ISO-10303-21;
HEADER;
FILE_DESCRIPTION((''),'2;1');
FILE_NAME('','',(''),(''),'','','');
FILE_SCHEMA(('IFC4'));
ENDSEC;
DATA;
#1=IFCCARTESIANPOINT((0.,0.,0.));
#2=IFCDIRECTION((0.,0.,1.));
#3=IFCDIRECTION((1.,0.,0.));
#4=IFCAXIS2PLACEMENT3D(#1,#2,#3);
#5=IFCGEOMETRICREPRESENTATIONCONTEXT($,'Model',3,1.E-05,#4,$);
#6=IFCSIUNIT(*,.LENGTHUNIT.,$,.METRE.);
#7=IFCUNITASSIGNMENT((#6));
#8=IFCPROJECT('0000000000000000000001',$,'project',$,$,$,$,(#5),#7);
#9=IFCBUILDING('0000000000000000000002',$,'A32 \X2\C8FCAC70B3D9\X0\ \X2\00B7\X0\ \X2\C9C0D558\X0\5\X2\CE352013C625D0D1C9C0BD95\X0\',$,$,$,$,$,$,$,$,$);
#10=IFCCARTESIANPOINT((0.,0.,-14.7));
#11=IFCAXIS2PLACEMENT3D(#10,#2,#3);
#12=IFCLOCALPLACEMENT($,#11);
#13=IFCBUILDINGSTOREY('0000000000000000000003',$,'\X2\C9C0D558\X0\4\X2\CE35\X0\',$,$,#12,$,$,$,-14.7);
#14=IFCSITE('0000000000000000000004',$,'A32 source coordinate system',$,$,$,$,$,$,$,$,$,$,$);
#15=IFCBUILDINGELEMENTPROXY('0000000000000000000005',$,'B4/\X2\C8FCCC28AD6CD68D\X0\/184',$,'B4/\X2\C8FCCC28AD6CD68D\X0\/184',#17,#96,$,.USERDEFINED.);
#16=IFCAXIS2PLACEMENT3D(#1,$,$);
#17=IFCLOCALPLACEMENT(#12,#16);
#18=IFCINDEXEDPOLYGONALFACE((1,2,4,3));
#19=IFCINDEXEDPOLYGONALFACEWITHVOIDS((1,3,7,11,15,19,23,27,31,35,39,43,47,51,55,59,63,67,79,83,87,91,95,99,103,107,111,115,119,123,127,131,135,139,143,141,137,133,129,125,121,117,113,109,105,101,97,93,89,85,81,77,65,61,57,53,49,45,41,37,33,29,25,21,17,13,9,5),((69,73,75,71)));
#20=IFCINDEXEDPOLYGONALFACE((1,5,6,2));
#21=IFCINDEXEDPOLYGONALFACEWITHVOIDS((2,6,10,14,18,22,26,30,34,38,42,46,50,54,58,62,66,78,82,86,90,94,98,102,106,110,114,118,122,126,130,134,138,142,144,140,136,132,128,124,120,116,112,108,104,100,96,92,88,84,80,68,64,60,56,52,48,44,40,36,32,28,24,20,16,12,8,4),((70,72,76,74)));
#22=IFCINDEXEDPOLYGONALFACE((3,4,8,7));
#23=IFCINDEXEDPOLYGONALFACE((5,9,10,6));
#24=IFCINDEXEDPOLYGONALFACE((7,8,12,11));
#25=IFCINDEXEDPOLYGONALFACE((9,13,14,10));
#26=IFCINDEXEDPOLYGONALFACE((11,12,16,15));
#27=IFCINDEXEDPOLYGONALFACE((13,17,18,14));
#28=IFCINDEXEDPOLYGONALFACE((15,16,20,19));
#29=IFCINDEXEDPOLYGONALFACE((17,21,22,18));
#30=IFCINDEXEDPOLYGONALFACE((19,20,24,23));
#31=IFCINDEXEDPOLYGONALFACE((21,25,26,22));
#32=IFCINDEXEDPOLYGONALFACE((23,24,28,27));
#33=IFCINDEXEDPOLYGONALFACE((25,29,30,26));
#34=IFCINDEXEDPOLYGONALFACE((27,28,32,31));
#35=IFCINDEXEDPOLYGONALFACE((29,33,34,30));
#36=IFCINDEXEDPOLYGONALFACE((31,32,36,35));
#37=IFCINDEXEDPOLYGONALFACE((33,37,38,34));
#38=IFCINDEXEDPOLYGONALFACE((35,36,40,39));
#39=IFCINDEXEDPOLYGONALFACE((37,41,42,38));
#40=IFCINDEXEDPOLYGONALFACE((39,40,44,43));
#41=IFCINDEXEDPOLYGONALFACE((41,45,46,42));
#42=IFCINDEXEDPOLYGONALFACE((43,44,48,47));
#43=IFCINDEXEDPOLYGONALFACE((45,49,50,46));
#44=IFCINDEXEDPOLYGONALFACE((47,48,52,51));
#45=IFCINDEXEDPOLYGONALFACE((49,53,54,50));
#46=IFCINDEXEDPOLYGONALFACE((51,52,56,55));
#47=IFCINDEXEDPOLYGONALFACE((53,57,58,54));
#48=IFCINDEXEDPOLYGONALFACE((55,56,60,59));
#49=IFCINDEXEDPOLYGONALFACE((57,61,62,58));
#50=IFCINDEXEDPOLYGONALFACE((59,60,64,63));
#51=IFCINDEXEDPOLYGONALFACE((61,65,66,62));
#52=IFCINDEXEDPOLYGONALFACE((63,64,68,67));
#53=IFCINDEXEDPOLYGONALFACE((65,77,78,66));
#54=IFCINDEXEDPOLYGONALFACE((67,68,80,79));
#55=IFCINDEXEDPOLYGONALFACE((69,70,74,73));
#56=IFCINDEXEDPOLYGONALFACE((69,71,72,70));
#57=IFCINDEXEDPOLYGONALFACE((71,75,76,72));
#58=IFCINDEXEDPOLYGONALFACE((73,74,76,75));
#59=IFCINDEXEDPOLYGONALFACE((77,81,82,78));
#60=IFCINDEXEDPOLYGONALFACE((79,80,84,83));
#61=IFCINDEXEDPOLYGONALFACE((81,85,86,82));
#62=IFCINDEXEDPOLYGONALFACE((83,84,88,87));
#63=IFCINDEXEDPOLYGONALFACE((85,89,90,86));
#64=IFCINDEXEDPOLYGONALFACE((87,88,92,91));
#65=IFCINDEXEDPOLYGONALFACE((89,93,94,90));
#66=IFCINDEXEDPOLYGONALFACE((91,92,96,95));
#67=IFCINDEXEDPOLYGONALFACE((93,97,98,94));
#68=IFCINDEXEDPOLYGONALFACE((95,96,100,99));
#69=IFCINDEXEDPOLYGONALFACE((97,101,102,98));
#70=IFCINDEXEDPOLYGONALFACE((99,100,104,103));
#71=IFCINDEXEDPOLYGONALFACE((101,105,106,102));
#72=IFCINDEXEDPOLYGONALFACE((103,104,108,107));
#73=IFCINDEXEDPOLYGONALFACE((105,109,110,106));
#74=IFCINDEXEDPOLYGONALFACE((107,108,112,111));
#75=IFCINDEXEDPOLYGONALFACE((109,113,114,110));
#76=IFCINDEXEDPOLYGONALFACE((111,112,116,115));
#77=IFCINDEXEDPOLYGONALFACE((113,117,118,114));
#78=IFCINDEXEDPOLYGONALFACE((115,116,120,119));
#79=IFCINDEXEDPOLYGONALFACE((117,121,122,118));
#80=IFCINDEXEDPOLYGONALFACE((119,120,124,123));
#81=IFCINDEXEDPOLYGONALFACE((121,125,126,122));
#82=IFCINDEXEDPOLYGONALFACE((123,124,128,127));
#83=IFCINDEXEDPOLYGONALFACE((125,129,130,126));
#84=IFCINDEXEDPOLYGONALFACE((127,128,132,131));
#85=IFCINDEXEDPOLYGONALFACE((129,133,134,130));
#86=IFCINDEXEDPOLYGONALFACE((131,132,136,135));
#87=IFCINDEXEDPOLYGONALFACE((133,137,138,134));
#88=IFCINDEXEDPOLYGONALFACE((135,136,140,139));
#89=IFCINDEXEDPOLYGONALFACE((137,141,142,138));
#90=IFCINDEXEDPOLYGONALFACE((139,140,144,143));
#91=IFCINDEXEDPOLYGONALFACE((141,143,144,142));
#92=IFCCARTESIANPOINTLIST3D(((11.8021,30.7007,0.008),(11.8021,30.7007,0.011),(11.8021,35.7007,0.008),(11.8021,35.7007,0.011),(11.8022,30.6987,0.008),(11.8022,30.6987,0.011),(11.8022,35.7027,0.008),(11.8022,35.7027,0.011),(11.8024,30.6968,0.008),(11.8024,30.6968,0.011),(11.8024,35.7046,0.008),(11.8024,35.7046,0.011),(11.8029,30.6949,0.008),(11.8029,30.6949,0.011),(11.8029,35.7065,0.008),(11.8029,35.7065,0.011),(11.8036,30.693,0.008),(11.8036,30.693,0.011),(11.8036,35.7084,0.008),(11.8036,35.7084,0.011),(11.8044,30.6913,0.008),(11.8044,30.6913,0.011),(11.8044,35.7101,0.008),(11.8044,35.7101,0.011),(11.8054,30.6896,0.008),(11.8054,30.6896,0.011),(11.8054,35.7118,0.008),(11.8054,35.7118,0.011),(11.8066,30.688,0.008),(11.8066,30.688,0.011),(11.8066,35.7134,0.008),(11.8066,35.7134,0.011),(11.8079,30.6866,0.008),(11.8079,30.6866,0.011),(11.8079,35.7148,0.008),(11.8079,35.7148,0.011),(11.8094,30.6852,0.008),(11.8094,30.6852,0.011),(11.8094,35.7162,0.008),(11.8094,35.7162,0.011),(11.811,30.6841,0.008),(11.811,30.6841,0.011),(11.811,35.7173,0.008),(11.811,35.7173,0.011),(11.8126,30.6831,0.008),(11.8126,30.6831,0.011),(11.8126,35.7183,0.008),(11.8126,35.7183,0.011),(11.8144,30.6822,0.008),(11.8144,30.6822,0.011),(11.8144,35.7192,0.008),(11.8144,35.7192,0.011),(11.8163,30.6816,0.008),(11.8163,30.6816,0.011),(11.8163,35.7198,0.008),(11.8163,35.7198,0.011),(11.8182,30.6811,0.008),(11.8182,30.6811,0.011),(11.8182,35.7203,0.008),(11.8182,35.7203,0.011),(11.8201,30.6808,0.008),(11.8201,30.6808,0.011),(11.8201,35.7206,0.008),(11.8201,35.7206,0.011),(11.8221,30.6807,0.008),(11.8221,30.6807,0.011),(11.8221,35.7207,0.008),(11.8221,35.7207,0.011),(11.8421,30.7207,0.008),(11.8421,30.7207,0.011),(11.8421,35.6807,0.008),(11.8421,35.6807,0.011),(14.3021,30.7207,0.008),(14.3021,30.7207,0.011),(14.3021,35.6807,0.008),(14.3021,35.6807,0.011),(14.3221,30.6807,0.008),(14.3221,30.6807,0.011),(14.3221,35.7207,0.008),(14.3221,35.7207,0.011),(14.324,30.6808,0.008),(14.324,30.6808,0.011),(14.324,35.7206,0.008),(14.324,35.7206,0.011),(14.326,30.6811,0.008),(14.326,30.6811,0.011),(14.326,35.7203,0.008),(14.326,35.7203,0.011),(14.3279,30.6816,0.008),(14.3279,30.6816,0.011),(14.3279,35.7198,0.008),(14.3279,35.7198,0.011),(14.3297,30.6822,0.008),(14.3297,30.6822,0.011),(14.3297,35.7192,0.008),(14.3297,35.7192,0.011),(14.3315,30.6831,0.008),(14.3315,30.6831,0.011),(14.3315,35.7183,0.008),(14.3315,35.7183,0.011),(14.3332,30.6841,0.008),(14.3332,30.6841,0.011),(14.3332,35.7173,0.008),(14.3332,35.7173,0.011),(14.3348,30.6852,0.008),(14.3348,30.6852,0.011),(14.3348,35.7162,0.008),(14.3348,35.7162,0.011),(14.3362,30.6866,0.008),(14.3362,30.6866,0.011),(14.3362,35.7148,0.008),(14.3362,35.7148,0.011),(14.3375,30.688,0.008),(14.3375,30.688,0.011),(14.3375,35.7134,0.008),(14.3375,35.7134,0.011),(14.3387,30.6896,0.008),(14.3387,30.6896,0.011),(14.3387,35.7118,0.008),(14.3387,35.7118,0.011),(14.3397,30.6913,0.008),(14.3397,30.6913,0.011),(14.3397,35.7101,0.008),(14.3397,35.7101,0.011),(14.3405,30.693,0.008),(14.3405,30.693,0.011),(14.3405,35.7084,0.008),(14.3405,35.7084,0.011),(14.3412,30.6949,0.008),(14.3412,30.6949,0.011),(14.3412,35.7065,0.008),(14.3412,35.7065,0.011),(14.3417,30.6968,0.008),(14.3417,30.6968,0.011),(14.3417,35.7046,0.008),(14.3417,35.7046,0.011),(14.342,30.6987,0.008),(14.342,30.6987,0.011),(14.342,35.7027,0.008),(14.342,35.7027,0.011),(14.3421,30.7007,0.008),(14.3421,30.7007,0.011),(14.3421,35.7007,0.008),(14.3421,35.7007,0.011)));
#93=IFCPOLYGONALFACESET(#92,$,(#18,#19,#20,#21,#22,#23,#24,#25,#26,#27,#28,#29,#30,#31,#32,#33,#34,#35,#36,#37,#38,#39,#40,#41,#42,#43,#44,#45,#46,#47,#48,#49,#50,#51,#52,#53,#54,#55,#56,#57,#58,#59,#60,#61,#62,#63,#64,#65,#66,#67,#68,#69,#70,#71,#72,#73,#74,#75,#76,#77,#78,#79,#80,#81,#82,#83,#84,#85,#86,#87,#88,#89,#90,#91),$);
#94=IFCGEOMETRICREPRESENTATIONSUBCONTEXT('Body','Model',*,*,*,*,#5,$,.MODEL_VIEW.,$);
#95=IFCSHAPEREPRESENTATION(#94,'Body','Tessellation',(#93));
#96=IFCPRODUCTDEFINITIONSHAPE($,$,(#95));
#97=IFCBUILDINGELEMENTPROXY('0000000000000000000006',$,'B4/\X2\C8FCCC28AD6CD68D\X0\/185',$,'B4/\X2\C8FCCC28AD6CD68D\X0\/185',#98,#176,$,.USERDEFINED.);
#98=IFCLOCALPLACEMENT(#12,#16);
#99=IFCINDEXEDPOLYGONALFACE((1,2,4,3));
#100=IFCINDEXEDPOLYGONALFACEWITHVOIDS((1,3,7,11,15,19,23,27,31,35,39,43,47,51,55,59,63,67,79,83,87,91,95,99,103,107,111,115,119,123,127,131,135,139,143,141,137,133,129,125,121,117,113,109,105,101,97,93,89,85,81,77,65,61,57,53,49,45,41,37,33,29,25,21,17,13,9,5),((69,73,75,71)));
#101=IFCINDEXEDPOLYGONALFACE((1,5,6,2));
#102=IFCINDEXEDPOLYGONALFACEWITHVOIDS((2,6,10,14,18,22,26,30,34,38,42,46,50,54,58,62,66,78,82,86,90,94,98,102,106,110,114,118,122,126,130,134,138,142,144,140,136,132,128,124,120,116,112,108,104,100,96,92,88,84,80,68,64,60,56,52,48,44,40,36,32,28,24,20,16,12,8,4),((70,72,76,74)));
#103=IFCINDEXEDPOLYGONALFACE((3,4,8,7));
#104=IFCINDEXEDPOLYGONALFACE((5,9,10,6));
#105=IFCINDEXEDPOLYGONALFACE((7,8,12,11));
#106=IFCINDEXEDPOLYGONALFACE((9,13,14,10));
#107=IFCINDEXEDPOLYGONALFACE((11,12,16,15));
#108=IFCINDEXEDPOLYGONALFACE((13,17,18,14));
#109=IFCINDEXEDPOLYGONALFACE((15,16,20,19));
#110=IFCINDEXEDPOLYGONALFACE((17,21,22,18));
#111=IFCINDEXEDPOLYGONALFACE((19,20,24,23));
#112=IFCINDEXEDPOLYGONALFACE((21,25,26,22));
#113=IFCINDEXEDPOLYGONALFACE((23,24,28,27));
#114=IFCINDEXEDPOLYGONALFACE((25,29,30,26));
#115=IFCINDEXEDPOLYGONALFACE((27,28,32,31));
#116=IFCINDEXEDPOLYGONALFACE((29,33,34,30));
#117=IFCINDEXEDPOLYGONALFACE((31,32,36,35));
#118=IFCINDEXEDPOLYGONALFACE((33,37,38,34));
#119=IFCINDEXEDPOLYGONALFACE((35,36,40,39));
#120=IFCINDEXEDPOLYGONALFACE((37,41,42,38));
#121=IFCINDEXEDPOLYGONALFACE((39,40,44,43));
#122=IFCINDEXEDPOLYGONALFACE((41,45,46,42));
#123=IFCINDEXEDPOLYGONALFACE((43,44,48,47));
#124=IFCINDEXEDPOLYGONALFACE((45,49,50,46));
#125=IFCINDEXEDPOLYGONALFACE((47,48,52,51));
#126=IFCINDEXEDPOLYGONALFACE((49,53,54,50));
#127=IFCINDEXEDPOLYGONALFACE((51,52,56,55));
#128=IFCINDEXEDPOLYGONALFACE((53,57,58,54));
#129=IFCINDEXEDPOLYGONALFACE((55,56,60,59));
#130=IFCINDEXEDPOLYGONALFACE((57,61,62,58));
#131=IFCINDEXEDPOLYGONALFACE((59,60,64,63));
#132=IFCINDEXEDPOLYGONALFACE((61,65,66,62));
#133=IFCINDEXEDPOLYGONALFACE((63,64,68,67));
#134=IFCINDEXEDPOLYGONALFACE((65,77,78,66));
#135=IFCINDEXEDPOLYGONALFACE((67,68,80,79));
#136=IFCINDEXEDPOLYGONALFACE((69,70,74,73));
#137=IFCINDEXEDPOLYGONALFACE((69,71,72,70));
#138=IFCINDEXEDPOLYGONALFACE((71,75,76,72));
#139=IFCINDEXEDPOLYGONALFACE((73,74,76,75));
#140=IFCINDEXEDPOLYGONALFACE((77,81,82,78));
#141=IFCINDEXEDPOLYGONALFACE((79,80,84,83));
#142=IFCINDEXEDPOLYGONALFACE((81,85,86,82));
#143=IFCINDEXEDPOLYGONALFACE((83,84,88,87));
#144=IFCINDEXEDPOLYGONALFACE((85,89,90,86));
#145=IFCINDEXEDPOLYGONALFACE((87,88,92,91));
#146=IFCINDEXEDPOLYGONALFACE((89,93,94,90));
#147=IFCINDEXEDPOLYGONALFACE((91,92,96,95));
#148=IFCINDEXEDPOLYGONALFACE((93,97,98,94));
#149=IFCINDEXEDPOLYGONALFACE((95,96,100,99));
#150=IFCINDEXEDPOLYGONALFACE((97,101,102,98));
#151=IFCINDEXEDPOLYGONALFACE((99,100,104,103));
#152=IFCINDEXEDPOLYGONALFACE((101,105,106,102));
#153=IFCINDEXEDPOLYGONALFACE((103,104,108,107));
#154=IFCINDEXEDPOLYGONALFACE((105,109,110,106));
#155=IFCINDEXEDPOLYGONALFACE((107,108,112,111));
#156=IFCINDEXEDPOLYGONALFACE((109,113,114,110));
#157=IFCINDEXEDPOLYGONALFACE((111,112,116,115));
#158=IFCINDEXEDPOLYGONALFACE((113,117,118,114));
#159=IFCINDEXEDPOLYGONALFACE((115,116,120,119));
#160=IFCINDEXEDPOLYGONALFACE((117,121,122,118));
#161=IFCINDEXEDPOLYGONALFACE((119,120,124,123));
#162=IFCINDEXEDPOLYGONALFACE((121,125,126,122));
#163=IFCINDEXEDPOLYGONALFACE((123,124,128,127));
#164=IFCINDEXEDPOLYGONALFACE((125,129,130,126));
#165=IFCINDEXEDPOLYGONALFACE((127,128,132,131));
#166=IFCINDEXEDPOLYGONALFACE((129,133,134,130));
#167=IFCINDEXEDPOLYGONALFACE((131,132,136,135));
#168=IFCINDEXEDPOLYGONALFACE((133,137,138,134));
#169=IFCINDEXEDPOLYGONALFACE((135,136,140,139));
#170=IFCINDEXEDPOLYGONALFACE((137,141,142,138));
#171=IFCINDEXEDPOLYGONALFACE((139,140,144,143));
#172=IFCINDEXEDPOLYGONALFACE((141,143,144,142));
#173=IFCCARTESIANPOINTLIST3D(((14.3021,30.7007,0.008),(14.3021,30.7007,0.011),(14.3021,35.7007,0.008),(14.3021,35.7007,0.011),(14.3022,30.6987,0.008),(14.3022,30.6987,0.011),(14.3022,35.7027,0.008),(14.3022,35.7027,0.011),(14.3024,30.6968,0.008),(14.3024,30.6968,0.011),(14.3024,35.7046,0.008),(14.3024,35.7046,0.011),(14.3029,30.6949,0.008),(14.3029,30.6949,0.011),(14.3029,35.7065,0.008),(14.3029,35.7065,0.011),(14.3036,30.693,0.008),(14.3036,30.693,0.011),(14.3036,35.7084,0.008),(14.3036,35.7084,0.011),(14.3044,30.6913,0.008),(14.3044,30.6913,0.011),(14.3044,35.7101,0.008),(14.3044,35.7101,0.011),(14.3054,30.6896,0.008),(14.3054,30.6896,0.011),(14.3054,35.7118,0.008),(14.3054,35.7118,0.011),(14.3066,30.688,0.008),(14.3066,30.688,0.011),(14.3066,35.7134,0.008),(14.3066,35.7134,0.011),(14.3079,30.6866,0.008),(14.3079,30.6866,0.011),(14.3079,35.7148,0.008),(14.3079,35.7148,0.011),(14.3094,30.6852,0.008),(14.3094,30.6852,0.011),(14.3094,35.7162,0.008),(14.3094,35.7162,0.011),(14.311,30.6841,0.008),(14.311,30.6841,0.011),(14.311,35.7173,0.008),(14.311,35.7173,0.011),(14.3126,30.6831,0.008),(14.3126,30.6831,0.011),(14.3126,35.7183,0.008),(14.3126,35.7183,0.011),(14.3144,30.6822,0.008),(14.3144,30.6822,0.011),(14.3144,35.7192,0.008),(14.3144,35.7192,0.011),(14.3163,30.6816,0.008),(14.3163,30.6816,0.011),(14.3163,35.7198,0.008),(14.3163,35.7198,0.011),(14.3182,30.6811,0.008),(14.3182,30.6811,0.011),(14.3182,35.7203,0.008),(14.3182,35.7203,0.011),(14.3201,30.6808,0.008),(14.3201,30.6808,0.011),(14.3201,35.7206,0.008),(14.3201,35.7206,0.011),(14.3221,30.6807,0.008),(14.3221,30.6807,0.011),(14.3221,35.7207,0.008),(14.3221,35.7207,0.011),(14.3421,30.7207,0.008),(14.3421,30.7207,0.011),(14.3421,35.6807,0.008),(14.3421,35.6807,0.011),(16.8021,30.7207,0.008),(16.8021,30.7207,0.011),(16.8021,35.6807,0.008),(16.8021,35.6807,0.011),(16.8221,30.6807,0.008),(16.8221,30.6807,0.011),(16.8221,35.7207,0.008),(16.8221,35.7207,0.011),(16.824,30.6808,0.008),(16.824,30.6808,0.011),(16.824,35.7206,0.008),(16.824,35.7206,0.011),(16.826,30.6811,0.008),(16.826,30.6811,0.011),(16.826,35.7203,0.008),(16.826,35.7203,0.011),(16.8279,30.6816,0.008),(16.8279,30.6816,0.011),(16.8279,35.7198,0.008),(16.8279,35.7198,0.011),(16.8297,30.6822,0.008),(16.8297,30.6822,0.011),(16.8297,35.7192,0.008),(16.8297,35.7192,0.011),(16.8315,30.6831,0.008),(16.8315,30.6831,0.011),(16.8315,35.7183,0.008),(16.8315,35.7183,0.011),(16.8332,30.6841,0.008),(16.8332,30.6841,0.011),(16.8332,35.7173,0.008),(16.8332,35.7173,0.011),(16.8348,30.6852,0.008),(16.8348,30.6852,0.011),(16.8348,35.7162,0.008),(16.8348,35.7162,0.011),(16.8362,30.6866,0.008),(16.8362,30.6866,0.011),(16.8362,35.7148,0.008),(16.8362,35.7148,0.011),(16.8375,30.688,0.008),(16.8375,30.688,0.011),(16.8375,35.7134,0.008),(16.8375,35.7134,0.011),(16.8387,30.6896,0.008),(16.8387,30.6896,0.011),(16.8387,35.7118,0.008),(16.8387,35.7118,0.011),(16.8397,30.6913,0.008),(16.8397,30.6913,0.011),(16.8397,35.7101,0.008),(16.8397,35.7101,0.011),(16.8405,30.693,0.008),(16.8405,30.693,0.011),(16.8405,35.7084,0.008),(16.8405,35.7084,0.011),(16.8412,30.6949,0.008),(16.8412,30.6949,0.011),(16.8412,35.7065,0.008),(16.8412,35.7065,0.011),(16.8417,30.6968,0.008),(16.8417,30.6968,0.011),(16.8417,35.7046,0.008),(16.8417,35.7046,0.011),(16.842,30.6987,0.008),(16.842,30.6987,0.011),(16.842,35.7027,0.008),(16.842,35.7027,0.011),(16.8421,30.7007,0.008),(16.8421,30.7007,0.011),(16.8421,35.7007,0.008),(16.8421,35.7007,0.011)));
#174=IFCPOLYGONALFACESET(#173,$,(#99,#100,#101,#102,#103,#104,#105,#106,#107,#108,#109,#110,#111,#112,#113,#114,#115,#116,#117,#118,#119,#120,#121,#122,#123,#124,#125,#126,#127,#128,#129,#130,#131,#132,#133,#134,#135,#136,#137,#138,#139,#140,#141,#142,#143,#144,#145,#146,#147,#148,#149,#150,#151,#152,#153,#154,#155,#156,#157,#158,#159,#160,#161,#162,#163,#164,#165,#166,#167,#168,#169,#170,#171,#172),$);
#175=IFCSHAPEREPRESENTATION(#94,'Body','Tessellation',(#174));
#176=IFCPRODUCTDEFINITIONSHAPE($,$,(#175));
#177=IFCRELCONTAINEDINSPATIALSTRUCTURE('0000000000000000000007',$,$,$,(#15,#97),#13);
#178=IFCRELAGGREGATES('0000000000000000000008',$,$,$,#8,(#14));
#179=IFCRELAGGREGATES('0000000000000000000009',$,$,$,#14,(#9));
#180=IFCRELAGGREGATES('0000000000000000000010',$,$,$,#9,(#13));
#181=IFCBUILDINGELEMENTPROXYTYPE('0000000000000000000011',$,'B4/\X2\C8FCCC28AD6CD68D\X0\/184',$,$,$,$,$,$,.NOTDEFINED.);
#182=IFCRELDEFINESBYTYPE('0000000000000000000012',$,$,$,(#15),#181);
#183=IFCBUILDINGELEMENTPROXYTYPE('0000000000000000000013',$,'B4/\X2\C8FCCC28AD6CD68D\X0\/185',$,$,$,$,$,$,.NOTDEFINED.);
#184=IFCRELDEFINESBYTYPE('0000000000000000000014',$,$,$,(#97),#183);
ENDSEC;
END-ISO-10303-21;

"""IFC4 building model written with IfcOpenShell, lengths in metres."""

from ifc_helpers import new_model, si_unit, frame, origin, origin_with_axes, place, context, subcontext, project, spatial, polyline, outline, extrude, source, transform, mapped, type_object, type_shapes, element, save


model = new_model("IFC4")

# Units and contexts
model_context = context("Model", 3, precision=1e-05, world=origin_with_axes())
body_context = subcontext(model_context, "Body", "Model", "MODEL_VIEW")
ifc_project = project(units=[si_unit("LENGTHUNIT", "METRE")], contexts=[model_context])

# Site, building, storey
site = spatial("IfcSite", under=ifc_project, Name="A32 source coordinate system")
building = spatial("IfcBuilding", under=site, Name="A32 주거동 · 지하5층–옥탑지붕")
storey_placement = place(None, frame((0.0, 0.0, -14.7), z_axis=(0.0, 0.0, 1.0), x_axis=(1.0, 0.0, 0.0)))
storey = spatial("IfcBuildingStorey", under=building, at=storey_placement, Name="지하4층", Elevation=-14.7)

# Building element proxies
building_element_proxy_type_1 = type_object("IfcBuildingElementProxyType", Name="B4/주차구획/184", PredefinedType="NOTDEFINED")
shared_shape_1 = source(origin(), body_context, "Body", "SweptSolid", [
    extrude(outline(polyline([(11.8021, 35.7007), (11.8022, 35.7027), (11.8024, 35.7046), (11.8029, 35.7065), (11.8036, 35.7084), (11.8044, 35.7101), (11.8054, 35.7118), (11.8066, 35.7134), (11.8079, 35.7148), (11.8094, 35.7162), (11.811, 35.7173), (11.8126, 35.7183), (11.8144, 35.7192), (11.8163, 35.7198), (11.8182, 35.7203), (11.8201, 35.7206), (11.8221, 35.7207), (14.3221, 35.7207), (14.324, 35.7206), (14.326, 35.7203), (14.3279, 35.7198), (14.3297, 35.7192), (14.3315, 35.7183), (14.3332, 35.7173), (14.3348, 35.7162), (14.3362, 35.7148), (14.3375, 35.7134), (14.3387, 35.7118), (14.3397, 35.7101), (14.3405, 35.7084), (14.3412, 35.7065), (14.3417, 35.7046), (14.342, 35.7027), (14.3421, 35.7007), (14.3421, 30.7007), (14.342, 30.6987), (14.3417, 30.6968), (14.3412, 30.6949), (14.3405, 30.693), (14.3397, 30.6913), (14.3387, 30.6896), (14.3375, 30.688), (14.3362, 30.6866), (14.3348, 30.6852), (14.3332, 30.6841), (14.3315, 30.6831), (14.3297, 30.6822), (14.3279, 30.6816), (14.326, 30.6811), (14.324, 30.6808), (14.3221, 30.6807), (11.8221, 30.6807), (11.8201, 30.6808), (11.8182, 30.6811), (11.8163, 30.6816), (11.8144, 30.6822), (11.8126, 30.6831), (11.811, 30.6841), (11.8094, 30.6852), (11.8079, 30.6866), (11.8066, 30.688), (11.8054, 30.6896), (11.8044, 30.6913), (11.8036, 30.693), (11.8029, 30.6949), (11.8024, 30.6968), (11.8022, 30.6987), (11.8021, 30.7007), (11.8021, 35.7007)]), holes=[polyline([(11.8421, 35.6807), (11.8421, 30.7207), (14.3021, 30.7207), (14.3021, 35.6807), (11.8421, 35.6807)])]), frame((0.0, 0.0, 0.008)), (0.0, 0.0, 1.0), 0.003),
])
type_shapes(building_element_proxy_type_1, [shared_shape_1])
proxy_1_placement = place(storey_placement, origin_with_axes())
element("IfcBuildingElementProxy", 1, at=proxy_1_placement, inside=storey, type_object=building_element_proxy_type_1, Name="B4/주차구획/184", ObjectType="B4/주차구획/184", PredefinedType="USERDEFINED", context=body_context, shape_type="MappedRepresentation", body=[
    mapped(shared_shape_1, transform((0.0, 0.0, 0.0), scale=1.0)),
])
building_element_proxy_type_2 = type_object("IfcBuildingElementProxyType", Name="B4/주차구획/185", PredefinedType="NOTDEFINED")
shared_shape_2 = source(origin(), body_context, "Body", "SweptSolid", [
    extrude(outline(polyline([(14.3021, 35.7007), (14.3022, 35.7027), (14.3024, 35.7046), (14.3029, 35.7065), (14.3036, 35.7084), (14.3044, 35.7101), (14.3054, 35.7118), (14.3066, 35.7134), (14.3079, 35.7148), (14.3094, 35.7162), (14.311, 35.7173), (14.3126, 35.7183), (14.3144, 35.7192), (14.3163, 35.7198), (14.3182, 35.7203), (14.3201, 35.7206), (14.3221, 35.7207), (16.8221, 35.7207), (16.824, 35.7206), (16.826, 35.7203), (16.8279, 35.7198), (16.8297, 35.7192), (16.8315, 35.7183), (16.8332, 35.7173), (16.8348, 35.7162), (16.8362, 35.7148), (16.8375, 35.7134), (16.8387, 35.7118), (16.8397, 35.7101), (16.8405, 35.7084), (16.8412, 35.7065), (16.8417, 35.7046), (16.842, 35.7027), (16.8421, 35.7007), (16.8421, 30.7007), (16.842, 30.6987), (16.8417, 30.6968), (16.8412, 30.6949), (16.8405, 30.693), (16.8397, 30.6913), (16.8387, 30.6896), (16.8375, 30.688), (16.8362, 30.6866), (16.8348, 30.6852), (16.8332, 30.6841), (16.8315, 30.6831), (16.8297, 30.6822), (16.8279, 30.6816), (16.826, 30.6811), (16.824, 30.6808), (16.8221, 30.6807), (14.3221, 30.6807), (14.3201, 30.6808), (14.3182, 30.6811), (14.3163, 30.6816), (14.3144, 30.6822), (14.3126, 30.6831), (14.311, 30.6841), (14.3094, 30.6852), (14.3079, 30.6866), (14.3066, 30.688), (14.3054, 30.6896), (14.3044, 30.6913), (14.3036, 30.693), (14.3029, 30.6949), (14.3024, 30.6968), (14.3022, 30.6987), (14.3021, 30.7007), (14.3021, 35.7007)]), holes=[polyline([(14.3421, 35.6807), (14.3421, 30.7207), (16.8021, 30.7207), (16.8021, 35.6807), (14.3421, 35.6807)])]), frame((0.0, 0.0, 0.008)), (0.0, 0.0, 1.0), 0.003),
])
type_shapes(building_element_proxy_type_2, [shared_shape_2])
proxy_2_placement = place(storey_placement, origin_with_axes())
element("IfcBuildingElementProxy", 2, at=proxy_2_placement, inside=storey, type_object=building_element_proxy_type_2, Name="B4/주차구획/185", ObjectType="B4/주차구획/185", PredefinedType="USERDEFINED", context=body_context, shape_type="MappedRepresentation", body=[
    mapped(shared_shape_2, transform((0.0, 0.0, 0.0), scale=1.0)),
])

save(model, "model.ifc")
